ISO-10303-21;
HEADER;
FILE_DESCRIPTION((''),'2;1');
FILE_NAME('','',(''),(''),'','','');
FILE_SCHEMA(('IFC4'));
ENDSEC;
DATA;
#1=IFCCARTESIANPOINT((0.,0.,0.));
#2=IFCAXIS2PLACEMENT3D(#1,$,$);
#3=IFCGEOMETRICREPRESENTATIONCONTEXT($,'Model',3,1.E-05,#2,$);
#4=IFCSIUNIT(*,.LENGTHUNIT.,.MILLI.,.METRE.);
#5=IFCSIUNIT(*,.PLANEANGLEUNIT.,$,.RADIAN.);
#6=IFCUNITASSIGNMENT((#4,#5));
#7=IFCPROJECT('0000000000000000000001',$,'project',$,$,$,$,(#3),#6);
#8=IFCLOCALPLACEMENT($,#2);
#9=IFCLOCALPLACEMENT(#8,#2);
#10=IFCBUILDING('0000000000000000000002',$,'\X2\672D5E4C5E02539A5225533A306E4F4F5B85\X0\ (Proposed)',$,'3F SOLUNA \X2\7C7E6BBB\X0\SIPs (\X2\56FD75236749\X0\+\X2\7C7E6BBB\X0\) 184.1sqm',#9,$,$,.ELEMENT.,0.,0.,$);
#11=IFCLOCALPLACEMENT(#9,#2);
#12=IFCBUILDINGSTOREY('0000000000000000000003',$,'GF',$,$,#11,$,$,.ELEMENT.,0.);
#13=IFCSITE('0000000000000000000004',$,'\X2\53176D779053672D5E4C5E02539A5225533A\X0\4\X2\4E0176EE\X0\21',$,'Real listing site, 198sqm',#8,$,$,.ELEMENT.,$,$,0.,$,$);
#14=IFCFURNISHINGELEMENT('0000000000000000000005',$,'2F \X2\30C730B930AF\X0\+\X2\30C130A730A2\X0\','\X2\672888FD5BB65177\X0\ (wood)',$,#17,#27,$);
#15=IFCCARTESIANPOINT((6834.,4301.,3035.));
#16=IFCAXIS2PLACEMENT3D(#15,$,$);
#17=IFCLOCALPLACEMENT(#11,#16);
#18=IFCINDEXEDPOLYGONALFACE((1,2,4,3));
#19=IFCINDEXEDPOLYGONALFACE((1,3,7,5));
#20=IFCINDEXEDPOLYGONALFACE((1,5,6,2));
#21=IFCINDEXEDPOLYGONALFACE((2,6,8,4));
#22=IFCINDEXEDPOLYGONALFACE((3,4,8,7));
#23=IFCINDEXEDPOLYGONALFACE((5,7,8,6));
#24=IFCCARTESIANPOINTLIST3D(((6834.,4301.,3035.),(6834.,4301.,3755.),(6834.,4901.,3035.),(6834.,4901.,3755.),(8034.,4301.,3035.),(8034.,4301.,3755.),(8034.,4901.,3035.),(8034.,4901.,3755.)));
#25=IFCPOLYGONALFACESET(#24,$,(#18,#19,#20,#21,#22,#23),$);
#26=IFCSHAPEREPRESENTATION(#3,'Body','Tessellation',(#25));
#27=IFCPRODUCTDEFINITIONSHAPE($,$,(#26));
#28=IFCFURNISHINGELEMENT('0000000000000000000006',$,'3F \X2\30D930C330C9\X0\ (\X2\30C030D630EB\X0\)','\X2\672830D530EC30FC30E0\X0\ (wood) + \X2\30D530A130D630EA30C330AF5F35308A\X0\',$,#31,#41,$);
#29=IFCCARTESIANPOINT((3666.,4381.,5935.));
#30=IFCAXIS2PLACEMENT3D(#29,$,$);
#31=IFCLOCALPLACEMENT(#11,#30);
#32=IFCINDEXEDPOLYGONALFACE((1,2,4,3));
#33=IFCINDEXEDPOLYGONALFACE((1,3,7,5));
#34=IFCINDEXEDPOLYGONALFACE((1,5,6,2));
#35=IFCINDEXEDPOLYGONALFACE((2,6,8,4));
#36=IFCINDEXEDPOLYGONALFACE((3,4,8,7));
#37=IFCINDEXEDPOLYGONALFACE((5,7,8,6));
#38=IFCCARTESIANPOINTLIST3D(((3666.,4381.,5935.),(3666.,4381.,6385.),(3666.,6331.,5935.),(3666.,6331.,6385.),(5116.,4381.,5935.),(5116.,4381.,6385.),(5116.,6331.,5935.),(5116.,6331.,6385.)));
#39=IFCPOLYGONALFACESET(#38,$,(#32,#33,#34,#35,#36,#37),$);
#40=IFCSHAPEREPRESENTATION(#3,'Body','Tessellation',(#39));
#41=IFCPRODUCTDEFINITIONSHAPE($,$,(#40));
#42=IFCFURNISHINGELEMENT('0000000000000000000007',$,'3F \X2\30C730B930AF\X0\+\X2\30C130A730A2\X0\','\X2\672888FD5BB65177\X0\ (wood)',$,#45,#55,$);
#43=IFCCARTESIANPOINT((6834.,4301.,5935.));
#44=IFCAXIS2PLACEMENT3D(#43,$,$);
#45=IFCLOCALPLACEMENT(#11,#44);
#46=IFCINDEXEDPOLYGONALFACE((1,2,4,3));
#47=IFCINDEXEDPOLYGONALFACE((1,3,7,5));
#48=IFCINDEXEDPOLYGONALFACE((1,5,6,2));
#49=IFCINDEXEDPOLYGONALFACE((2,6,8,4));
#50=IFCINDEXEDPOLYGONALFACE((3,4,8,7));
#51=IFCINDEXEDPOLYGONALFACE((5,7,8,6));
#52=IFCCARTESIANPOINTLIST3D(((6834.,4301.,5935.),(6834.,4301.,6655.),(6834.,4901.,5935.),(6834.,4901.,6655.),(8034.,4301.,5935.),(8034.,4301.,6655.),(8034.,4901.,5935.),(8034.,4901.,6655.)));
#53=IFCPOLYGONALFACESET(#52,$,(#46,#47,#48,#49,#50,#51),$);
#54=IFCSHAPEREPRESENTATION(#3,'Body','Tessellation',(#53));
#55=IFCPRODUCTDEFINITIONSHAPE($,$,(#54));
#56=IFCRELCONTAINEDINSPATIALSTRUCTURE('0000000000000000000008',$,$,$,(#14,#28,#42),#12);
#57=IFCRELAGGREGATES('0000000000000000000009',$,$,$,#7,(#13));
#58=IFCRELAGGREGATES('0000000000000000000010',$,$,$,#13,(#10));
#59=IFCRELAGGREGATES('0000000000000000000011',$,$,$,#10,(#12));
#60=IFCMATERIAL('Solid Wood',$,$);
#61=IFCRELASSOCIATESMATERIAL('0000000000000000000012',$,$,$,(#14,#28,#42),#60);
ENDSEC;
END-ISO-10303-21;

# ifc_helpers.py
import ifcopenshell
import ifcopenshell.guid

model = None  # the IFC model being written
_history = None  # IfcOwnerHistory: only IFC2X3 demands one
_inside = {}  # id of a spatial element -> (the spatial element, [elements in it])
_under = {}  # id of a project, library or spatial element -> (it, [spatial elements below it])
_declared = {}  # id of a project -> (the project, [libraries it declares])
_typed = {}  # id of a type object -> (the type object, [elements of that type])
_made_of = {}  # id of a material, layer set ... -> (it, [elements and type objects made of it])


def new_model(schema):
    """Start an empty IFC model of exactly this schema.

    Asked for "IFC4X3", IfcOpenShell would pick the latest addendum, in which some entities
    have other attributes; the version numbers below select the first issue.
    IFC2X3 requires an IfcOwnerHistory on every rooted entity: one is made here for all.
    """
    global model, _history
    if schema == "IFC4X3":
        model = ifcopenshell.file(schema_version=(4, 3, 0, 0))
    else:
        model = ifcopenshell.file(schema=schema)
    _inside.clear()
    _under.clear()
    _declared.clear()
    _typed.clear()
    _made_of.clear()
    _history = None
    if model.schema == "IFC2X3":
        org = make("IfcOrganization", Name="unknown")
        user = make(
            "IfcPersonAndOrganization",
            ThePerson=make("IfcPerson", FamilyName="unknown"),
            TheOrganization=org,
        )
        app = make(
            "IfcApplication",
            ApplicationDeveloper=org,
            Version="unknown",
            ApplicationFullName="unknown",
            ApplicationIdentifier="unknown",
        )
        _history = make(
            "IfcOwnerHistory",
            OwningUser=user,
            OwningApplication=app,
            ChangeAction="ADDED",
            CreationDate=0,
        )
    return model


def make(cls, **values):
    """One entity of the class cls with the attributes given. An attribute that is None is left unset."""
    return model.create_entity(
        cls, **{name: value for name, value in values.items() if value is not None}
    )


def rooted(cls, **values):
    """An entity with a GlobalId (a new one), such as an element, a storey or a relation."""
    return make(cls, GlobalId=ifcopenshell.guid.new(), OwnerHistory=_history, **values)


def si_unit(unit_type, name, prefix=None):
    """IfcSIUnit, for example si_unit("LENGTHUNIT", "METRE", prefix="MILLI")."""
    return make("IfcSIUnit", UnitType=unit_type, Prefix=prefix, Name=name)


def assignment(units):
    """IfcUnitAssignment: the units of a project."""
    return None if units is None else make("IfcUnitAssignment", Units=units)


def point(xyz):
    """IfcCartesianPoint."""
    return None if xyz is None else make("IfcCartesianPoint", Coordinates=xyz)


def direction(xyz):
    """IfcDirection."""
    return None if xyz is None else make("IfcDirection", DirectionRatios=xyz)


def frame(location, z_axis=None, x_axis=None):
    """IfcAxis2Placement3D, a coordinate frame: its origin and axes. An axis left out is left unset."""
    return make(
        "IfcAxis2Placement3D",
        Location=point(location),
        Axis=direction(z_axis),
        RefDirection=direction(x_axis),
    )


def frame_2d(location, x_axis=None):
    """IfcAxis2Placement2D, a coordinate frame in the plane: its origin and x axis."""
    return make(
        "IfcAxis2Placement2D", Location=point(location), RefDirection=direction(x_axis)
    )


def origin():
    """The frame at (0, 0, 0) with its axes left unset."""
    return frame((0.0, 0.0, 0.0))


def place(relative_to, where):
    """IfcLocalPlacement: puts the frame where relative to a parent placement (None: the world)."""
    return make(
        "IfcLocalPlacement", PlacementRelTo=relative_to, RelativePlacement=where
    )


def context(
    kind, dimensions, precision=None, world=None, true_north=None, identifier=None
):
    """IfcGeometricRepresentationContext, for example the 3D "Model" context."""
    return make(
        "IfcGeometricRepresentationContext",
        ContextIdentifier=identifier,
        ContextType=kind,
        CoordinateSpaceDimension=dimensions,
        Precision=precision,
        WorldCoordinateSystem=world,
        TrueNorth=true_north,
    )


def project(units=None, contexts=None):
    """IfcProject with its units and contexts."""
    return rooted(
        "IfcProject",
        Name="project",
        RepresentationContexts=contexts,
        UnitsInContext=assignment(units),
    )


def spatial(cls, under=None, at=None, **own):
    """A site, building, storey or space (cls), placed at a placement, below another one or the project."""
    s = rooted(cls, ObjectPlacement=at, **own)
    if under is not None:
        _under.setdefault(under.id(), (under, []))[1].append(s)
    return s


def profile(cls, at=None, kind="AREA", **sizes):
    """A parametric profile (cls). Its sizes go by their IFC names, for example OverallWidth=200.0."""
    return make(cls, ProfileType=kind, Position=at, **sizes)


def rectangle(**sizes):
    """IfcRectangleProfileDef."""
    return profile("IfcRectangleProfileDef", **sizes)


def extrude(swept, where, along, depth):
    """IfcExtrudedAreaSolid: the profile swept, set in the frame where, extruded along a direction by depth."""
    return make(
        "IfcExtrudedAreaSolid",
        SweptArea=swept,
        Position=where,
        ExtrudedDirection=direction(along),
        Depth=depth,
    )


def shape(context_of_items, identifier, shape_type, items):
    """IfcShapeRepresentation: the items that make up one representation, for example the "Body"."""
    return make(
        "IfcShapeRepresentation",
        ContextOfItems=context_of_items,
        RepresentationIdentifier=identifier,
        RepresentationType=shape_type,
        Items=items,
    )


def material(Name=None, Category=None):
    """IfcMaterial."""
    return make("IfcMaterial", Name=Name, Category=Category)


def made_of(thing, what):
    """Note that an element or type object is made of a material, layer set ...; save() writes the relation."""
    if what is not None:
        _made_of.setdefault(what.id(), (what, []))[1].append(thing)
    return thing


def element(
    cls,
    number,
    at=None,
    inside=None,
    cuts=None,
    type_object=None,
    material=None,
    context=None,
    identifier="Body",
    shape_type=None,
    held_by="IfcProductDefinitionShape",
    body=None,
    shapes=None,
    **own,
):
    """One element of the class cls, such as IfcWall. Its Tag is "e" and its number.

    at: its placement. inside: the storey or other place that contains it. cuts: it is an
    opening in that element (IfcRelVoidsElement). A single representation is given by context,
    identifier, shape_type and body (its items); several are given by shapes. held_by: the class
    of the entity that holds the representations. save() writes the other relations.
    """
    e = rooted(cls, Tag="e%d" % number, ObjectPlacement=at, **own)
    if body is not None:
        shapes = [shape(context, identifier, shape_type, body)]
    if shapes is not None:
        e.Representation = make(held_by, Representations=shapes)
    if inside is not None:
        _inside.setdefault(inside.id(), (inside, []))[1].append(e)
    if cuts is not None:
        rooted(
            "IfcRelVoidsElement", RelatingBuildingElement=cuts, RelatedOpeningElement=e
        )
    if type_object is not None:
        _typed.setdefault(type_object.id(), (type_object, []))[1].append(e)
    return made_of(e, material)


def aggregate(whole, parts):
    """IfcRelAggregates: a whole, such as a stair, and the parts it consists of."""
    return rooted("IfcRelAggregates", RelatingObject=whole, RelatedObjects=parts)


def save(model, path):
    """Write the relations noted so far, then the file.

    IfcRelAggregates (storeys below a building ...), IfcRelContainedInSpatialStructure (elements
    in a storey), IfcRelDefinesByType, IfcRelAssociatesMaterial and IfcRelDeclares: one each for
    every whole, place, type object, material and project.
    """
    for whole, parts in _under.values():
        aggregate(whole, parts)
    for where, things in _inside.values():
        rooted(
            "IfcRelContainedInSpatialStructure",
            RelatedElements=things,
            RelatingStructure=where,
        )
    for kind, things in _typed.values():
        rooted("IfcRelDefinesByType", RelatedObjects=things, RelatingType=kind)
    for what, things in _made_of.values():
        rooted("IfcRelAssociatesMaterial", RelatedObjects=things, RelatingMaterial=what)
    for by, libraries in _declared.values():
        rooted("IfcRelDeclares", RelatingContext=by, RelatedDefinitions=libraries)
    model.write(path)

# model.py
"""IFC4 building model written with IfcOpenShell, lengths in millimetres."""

from ifc_helpers import new_model, si_unit, frame, frame_2d, origin, place, context, project, spatial, rectangle, extrude, material, element, save


model = new_model("IFC4")

# Units and contexts
model_context = context("Model", 3, precision=1e-05, world=origin())
ifc_project = project(units=[si_unit("LENGTHUNIT", "METRE", prefix="MILLI"), si_unit("PLANEANGLEUNIT", "RADIAN")], contexts=[model_context])

# Site, building, storey
site_placement = place(None, origin())
site = spatial("IfcSite", under=ifc_project, at=site_placement, Name="北海道札幌市厚別区4丁目21", ObjectType="Real listing site, 198sqm", CompositionType="ELEMENT", RefElevation=0.0)
building_placement = place(site_placement, origin())
building = spatial("IfcBuilding", under=site, at=building_placement, Name="札幌市厚別区の住宅 (Proposed)", ObjectType="3F SOLUNA 籾殻SIPs (国産杉+籾殻) 184.1sqm", CompositionType="ELEMENT", ElevationOfRefHeight=0.0, ElevationOfTerrain=0.0)
storey_placement = place(building_placement, origin())
storey = spatial("IfcBuildingStorey", under=building, at=storey_placement, Name="GF", CompositionType="ELEMENT", Elevation=0.0)

# Shared definitions
ifc_material_1 = material(Name="Solid Wood")

# Furnishing elements
furnishing_1_placement = place(storey_placement, frame((6834.0, 4301.0, 3035.0)))
element("IfcFurnishingElement", 1, at=furnishing_1_placement, inside=storey, material=ifc_material_1, Name="2F デスク+チェア", Description="木製家具 (wood)", context=model_context, shape_type="SweptSolid", body=[
    extrude(rectangle(XDim=1200.0, YDim=600.0, at=frame_2d((600.0, 300.0))), frame((6834.0, 4301.0, 3035.0)), (0.0, 0.0, 1.0), 720.0),
])
furnishing_2_placement = place(storey_placement, frame((3666.0, 4381.0, 5935.0)))
element("IfcFurnishingElement", 2, at=furnishing_2_placement, inside=storey, material=ifc_material_1, Name="3F ベッド (ダブル)", Description="木フレーム (wood) + ファブリック張り", context=model_context, shape_type="SweptSolid", body=[
    extrude(rectangle(XDim=1450.0, YDim=1950.0, at=frame_2d((725.0, 975.0))), frame((3666.0, 4381.0, 5935.0)), (0.0, 0.0, 1.0), 450.0),
])
furnishing_3_placement = place(storey_placement, frame((6834.0, 4301.0, 5935.0)))
element("IfcFurnishingElement", 3, at=furnishing_3_placement, inside=storey, material=ifc_material_1, Name="3F デスク+チェア", Description="木製家具 (wood)", context=model_context, shape_type="SweptSolid", body=[
    extrude(rectangle(XDim=1200.0, YDim=600.0, at=frame_2d((600.0, 300.0))), frame((6834.0, 4301.0, 5935.0)), (0.0, 0.0, 1.0), 720.0),
])

save(model, "model.ifc")
